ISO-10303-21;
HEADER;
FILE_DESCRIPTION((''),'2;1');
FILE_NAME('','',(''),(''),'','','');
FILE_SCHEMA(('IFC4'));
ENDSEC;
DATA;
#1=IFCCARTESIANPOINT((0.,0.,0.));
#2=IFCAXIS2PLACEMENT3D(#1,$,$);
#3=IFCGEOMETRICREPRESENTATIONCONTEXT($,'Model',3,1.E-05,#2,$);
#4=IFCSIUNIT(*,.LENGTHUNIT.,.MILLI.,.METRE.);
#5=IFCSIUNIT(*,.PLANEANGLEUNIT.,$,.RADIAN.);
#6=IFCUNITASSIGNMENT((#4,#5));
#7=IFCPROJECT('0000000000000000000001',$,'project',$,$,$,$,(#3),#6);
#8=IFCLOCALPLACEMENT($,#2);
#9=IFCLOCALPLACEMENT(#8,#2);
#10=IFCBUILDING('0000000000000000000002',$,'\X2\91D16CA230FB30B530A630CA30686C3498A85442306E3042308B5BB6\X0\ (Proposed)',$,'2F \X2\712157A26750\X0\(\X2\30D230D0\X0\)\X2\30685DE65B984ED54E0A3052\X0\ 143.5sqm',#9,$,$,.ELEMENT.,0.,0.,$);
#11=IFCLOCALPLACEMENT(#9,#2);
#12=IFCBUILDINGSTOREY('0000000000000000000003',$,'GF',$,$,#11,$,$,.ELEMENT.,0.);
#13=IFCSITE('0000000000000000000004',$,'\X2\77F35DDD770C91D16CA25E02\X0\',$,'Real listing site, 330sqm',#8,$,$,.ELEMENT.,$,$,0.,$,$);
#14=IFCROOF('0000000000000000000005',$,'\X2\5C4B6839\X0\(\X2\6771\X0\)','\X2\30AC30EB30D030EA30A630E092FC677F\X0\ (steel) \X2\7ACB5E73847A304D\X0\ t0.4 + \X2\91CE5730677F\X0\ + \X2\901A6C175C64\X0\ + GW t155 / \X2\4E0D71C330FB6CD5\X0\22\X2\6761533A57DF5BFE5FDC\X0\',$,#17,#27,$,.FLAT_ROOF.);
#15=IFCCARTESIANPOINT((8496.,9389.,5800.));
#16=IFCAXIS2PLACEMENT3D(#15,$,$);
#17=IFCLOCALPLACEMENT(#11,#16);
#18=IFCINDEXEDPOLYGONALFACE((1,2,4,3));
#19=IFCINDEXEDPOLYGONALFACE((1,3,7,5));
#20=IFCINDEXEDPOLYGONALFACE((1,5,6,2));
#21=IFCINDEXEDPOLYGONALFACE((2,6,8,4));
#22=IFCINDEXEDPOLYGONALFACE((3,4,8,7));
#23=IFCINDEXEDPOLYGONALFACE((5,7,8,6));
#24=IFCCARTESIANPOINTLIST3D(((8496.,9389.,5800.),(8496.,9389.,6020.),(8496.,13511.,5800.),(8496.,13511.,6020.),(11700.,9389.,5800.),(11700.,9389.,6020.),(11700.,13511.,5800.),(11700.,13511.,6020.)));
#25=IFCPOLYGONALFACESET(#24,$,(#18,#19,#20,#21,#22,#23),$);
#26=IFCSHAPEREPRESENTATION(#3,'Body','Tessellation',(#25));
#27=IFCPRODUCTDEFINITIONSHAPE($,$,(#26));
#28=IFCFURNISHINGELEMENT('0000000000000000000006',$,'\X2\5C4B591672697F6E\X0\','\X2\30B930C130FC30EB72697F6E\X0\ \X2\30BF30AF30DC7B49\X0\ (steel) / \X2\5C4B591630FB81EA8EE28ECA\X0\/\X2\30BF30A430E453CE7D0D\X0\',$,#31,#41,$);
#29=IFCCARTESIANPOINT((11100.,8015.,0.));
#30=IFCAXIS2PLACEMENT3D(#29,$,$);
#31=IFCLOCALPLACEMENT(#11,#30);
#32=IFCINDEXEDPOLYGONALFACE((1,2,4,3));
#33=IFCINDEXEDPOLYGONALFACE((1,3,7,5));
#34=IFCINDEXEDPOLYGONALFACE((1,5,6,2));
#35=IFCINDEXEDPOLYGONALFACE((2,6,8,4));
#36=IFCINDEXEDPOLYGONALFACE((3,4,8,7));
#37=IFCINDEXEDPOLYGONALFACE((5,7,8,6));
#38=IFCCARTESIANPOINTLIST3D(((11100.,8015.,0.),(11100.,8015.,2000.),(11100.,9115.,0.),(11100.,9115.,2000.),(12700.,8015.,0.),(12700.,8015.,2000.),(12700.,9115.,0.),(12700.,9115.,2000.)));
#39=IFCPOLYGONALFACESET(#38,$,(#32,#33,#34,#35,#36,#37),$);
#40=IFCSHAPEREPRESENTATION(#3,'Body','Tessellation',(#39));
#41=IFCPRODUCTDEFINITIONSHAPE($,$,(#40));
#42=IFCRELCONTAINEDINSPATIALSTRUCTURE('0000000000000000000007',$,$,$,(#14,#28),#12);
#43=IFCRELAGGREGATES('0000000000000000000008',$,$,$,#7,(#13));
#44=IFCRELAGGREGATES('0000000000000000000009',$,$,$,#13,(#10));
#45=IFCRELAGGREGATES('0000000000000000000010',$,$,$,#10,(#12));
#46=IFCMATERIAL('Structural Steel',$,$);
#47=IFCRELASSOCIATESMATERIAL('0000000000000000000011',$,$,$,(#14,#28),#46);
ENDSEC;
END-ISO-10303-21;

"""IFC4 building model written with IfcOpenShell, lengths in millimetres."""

from ifc_helpers import new_model, si_unit, frame, frame_2d, origin, place, context, project, spatial, rectangle, extrude, material, element, save


model = new_model("IFC4")

# Units and contexts
model_context = context("Model", 3, precision=1e-05, world=origin())
ifc_project = project(units=[si_unit("LENGTHUNIT", "METRE", prefix="MILLI"), si_unit("PLANEANGLEUNIT", "RADIAN")], contexts=[model_context])

# Site, building, storey
site_placement = place(None, origin())
site = spatial("IfcSite", under=ifc_project, at=site_placement, Name="石川県金沢市", ObjectType="Real listing site, 330sqm", CompositionType="ELEMENT", RefElevation=0.0)
building_placement = place(site_placement, origin())
building = spatial("IfcBuilding", under=site, at=building_placement, Name="金沢・サウナと水風呂のある家 (Proposed)", ObjectType="2F 無垢材(ヒバ)と左官仕上げ 143.5sqm", CompositionType="ELEMENT", ElevationOfRefHeight=0.0, ElevationOfTerrain=0.0)
storey_placement = place(building_placement, origin())
storey = spatial("IfcBuildingStorey", under=building, at=storey_placement, Name="GF", CompositionType="ELEMENT", Elevation=0.0)

# Roof
ifc_material_1 = material(Name="Structural Steel")
for number, where, name in (
    (1, (8496.0, 9389.0, 5800.0), "屋根(東)"),
):
    element("IfcRoof", number, at=place(storey_placement, frame(where)), inside=storey, material=ifc_material_1, Name=name, Description="ガルバリウム鋼板 (steel) 立平葺き t0.4 + 野地板 + 通気層 + GW t155 / 不燃・法22条区域対応", PredefinedType="FLAT_ROOF", context=model_context, shape_type="SweptSolid", body=[
        extrude(rectangle(XDim=3204.0, YDim=4122.0, at=frame_2d((1602.0, 2061.0))), frame((8496.0, 9389.0, 5800.0)), (0.0, 0.0, 1.0), 220.0),
    ])

# Furnishing element
furnishing_placement = place(storey_placement, frame((11100.0, 8015.0, 0.0)))
element("IfcFurnishingElement", 2, at=furnishing_placement, inside=storey, material=ifc_material_1, Name="屋外物置", Description="スチール物置 タクボ等 (steel) / 屋外・自転車/タイヤ収納", context=model_context, shape_type="SweptSolid", body=[
    extrude(rectangle(XDim=1600.0, YDim=1100.0, at=frame_2d((800.0, 550.0))), frame((11100.0, 8015.0, 0.0)), (0.0, 0.0, 1.0), 2000.0),
])

save(model, "model.ifc")
